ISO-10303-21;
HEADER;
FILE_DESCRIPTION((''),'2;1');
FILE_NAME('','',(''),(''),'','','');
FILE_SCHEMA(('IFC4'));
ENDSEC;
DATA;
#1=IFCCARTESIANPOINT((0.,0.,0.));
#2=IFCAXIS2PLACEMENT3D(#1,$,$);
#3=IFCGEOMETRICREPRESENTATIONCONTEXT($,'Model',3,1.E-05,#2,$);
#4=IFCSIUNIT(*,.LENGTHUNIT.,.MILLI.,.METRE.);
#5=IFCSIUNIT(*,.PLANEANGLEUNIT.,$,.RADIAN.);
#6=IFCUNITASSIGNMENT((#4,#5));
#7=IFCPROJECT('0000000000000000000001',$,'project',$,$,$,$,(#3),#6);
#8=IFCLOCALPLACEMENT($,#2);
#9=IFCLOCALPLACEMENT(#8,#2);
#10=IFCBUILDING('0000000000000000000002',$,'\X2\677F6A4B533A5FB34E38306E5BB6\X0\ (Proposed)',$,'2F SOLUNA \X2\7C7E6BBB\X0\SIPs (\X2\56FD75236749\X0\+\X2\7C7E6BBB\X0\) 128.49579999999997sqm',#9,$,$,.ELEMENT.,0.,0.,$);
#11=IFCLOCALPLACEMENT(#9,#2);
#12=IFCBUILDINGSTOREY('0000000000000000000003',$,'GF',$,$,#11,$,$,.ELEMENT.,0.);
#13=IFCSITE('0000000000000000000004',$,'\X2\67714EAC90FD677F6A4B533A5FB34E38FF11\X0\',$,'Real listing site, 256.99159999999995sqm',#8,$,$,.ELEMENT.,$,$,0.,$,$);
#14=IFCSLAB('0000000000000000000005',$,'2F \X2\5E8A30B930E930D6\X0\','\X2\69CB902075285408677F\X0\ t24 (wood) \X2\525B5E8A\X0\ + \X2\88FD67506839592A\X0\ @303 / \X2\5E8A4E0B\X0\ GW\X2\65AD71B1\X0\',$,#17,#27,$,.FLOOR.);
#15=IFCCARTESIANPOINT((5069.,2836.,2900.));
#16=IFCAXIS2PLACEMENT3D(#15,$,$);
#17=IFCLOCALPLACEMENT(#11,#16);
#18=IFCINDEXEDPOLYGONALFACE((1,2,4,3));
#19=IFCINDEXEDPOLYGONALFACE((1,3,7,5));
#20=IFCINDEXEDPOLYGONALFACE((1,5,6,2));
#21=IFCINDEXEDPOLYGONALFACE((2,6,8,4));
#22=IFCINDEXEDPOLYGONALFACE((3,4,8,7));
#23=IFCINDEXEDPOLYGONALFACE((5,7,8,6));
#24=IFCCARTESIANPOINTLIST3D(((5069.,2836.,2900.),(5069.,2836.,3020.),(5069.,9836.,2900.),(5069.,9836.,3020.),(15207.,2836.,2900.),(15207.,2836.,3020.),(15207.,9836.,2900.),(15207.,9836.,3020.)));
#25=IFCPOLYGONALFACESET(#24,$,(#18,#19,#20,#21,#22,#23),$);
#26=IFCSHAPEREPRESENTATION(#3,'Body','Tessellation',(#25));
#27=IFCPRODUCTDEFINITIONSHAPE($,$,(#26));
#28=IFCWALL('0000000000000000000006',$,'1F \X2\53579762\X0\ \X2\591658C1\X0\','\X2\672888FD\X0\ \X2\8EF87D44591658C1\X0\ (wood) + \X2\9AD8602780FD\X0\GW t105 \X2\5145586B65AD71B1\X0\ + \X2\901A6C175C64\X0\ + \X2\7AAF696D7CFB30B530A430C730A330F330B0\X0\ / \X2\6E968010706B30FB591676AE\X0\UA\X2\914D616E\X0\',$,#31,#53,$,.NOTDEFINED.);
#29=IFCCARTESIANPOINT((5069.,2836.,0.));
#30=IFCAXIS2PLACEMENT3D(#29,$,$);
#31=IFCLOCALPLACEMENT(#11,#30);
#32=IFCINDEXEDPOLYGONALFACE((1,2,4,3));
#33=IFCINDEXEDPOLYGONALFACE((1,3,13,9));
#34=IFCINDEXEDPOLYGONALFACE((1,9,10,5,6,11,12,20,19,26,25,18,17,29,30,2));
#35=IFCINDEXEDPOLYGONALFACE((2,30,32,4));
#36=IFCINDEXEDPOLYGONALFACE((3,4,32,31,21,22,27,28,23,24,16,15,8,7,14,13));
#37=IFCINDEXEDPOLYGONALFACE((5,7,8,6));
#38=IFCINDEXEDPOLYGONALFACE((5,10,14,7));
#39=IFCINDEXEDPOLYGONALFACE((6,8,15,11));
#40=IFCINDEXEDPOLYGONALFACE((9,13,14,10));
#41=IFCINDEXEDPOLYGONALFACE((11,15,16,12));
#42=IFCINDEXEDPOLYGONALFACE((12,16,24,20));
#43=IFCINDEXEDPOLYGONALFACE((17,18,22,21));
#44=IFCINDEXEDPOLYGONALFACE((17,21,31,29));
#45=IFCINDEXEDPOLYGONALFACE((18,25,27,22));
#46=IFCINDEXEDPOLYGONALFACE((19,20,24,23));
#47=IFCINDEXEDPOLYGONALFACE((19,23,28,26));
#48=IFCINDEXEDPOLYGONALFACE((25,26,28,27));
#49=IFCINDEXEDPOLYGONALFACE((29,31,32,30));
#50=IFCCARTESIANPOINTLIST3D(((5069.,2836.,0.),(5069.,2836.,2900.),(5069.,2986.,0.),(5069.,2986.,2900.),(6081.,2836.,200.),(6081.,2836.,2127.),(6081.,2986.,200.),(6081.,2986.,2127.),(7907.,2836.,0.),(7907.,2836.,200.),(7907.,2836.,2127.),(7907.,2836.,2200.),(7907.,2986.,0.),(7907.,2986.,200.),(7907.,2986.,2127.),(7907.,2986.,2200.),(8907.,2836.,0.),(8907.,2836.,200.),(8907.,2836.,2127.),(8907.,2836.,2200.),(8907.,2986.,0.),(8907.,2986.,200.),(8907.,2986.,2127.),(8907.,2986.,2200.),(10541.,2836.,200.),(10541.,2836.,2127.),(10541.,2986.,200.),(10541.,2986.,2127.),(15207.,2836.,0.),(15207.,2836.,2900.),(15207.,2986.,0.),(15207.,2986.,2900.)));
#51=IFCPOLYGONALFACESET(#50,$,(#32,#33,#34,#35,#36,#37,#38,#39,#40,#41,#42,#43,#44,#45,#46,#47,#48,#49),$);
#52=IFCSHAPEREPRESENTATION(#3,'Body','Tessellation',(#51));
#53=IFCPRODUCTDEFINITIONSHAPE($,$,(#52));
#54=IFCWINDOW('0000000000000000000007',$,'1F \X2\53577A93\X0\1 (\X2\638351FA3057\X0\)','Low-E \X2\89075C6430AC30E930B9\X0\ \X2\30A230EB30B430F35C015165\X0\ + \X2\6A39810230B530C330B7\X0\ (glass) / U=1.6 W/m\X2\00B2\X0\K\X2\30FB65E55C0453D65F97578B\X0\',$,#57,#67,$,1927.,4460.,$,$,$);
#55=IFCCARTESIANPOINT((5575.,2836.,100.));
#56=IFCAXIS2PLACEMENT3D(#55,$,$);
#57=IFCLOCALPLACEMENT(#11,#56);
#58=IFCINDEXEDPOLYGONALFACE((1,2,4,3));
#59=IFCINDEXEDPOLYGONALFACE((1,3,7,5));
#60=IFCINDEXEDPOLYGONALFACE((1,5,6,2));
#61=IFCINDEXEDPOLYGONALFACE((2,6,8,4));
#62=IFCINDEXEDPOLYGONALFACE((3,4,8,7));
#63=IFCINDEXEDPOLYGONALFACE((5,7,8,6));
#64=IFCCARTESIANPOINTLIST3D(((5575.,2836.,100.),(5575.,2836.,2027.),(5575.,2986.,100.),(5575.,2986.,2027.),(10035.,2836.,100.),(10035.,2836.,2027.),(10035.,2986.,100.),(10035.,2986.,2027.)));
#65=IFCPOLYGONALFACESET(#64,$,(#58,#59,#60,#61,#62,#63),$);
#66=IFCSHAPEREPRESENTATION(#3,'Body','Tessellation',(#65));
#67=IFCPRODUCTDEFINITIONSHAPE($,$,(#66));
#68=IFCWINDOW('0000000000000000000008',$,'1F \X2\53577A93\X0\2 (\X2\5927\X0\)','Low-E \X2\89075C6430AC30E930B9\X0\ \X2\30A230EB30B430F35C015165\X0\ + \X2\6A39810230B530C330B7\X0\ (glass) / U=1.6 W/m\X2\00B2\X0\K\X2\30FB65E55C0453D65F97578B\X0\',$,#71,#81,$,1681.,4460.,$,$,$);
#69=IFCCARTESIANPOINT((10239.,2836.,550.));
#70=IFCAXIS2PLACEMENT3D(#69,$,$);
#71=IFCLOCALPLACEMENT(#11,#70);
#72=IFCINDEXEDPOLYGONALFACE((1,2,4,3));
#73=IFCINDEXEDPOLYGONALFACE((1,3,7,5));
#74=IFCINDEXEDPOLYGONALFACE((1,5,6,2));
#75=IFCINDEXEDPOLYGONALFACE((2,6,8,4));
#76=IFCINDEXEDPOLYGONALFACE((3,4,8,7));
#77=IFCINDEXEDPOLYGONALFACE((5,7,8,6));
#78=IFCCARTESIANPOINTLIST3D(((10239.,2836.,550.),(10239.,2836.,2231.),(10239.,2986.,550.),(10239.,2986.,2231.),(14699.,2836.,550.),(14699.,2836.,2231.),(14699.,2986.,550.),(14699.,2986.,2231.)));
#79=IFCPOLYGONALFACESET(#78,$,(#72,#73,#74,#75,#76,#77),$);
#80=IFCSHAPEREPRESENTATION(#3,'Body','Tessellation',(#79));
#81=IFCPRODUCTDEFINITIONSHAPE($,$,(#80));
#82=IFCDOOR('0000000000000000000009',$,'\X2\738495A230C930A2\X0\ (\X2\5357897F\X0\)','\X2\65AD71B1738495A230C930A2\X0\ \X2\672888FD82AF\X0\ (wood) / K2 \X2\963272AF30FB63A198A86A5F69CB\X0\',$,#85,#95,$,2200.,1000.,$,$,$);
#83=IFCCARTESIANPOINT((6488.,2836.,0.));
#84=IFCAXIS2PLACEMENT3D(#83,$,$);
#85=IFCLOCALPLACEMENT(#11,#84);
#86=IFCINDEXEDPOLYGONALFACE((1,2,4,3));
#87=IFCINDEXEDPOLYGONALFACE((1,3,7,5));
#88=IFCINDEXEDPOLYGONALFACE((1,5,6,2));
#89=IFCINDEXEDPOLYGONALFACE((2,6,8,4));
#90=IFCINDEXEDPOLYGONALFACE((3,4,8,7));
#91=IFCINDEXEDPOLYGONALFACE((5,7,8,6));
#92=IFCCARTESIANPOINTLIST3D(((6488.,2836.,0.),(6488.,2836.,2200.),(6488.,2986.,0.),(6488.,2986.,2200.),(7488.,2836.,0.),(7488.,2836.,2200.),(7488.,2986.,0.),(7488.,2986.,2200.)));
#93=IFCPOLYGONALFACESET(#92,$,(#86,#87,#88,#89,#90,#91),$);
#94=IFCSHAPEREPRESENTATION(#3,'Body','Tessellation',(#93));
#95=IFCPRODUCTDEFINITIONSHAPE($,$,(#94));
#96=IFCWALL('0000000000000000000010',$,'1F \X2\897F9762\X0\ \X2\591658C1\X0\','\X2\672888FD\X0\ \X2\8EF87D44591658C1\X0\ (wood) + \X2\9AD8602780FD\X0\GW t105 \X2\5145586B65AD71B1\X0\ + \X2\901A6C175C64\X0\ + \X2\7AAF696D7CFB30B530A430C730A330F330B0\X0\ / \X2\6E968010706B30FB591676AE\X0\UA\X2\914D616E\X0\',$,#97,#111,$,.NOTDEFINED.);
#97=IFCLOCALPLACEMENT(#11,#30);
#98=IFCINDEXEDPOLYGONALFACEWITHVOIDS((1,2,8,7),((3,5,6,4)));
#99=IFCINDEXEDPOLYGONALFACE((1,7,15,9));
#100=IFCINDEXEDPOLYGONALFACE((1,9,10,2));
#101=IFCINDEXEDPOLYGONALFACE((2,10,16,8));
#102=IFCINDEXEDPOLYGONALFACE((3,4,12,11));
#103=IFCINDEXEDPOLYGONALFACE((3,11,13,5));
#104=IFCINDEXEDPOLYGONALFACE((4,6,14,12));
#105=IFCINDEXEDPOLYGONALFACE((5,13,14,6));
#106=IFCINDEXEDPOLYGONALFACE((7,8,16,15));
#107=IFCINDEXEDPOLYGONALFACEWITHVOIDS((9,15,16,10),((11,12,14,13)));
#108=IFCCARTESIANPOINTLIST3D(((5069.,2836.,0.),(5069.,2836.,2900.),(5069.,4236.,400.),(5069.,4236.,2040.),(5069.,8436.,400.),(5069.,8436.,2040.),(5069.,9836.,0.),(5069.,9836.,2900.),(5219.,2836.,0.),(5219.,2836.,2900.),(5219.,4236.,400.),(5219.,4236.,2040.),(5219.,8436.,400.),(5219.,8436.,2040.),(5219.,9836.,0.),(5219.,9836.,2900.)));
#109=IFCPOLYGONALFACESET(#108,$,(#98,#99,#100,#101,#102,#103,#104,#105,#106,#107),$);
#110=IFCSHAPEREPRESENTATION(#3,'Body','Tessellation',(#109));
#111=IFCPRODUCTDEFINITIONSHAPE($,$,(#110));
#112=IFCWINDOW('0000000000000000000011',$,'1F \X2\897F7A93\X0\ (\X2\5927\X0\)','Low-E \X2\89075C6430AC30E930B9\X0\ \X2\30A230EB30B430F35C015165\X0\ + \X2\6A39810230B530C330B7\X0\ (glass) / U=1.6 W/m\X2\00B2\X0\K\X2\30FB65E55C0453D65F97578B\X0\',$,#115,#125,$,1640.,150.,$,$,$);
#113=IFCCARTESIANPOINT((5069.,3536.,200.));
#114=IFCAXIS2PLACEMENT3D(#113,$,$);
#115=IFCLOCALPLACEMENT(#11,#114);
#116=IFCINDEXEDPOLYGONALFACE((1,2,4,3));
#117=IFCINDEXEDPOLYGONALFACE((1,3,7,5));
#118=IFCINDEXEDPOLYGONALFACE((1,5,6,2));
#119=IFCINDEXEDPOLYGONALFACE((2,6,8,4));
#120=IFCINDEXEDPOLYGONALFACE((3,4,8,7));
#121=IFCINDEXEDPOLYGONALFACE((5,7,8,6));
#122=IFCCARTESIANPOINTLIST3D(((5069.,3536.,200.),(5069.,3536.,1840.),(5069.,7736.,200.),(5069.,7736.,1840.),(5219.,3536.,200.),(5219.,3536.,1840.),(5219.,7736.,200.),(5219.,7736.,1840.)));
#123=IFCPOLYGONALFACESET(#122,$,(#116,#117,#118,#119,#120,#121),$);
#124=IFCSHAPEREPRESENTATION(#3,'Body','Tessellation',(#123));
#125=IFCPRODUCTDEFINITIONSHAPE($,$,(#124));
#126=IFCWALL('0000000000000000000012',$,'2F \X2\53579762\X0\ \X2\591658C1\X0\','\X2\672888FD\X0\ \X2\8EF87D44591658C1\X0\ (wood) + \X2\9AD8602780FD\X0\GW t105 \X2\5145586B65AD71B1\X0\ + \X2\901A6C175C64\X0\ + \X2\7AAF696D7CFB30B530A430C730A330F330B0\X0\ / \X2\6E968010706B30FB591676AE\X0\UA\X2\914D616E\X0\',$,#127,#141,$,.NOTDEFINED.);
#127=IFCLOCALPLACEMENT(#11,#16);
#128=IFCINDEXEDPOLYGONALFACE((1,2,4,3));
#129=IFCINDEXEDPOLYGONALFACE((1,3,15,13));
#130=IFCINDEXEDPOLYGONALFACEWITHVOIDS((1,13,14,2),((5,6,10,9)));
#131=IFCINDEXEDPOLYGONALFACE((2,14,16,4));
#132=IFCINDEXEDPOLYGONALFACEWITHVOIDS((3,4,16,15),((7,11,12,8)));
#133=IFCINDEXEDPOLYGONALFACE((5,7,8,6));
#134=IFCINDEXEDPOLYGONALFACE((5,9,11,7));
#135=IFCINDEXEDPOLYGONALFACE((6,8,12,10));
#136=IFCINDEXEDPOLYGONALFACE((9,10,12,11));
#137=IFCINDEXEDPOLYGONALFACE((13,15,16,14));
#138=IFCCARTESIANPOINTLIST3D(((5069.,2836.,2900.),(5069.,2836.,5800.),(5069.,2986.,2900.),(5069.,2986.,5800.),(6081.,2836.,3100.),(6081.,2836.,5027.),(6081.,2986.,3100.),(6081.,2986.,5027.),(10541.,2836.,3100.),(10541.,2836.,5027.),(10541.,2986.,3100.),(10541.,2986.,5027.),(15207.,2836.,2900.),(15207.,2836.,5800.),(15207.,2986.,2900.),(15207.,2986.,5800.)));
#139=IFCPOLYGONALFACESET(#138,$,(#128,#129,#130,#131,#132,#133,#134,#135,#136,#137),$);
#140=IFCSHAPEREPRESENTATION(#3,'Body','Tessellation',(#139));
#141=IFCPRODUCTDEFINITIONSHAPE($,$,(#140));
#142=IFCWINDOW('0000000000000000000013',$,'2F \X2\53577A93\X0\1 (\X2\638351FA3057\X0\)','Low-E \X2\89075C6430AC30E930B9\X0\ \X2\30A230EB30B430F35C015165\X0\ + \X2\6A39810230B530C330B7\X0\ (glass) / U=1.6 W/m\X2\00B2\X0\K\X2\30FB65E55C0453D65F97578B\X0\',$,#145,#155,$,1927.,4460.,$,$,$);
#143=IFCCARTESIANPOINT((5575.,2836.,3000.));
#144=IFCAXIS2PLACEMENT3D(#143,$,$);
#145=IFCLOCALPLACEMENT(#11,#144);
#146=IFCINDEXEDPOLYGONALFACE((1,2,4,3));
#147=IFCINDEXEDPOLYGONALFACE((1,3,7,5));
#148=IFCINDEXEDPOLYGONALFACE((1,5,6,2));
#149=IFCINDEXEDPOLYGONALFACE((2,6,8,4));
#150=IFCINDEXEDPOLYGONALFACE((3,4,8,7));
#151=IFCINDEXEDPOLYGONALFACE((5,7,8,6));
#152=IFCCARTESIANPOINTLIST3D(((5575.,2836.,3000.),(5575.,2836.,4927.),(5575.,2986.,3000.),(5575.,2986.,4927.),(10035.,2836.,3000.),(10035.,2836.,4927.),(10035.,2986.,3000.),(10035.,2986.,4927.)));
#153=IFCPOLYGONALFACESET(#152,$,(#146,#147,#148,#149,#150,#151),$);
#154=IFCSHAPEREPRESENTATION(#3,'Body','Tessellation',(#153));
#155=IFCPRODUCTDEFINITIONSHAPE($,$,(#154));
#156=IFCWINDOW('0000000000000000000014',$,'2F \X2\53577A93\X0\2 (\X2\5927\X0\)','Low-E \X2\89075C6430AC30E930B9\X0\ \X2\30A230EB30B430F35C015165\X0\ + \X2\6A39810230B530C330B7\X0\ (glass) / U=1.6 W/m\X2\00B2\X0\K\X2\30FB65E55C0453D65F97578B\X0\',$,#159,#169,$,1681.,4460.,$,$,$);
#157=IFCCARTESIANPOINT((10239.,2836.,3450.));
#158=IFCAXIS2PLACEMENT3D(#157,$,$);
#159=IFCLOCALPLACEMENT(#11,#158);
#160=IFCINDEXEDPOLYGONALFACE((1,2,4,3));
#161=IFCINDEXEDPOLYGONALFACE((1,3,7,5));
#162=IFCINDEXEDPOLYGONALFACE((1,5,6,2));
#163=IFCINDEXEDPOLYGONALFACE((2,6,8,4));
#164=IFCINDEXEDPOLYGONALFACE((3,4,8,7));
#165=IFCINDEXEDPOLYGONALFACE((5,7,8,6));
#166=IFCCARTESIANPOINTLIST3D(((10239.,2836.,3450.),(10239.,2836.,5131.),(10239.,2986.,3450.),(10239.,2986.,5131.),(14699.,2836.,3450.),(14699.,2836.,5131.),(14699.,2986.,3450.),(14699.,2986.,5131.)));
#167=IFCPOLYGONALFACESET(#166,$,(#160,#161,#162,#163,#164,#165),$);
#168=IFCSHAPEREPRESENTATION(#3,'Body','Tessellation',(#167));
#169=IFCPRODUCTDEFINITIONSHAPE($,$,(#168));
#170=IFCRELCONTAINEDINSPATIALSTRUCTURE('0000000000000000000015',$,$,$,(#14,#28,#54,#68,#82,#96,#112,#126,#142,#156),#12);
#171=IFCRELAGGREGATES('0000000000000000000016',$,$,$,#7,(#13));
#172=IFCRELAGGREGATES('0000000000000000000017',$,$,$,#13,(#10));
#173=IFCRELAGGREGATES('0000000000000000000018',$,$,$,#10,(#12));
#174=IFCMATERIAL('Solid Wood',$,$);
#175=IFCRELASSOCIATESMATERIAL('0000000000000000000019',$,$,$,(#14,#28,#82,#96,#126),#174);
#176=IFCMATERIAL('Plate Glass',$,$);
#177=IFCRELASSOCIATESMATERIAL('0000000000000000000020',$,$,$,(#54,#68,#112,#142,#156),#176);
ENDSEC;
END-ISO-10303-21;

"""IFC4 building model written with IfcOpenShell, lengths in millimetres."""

from ifc_helpers import new_model, si_unit, frame, frame_2d, origin, place, context, project, spatial, rectangle, extrude, material, element, fill, save


model = new_model("IFC4")

# Units and contexts
model_context = context("Model", 3, precision=1e-05, world=origin())
ifc_project = project(units=[si_unit("LENGTHUNIT", "METRE", prefix="MILLI"), si_unit("PLANEANGLEUNIT", "RADIAN")], contexts=[model_context])

# Site, building, storey
site_placement = place(None, origin())
site = spatial("IfcSite", under=ifc_project, at=site_placement, Name="東京都板橋区徳丸１", ObjectType="Real listing site, 256.99159999999995sqm", CompositionType="ELEMENT", RefElevation=0.0)
building_placement = place(site_placement, origin())
building = spatial("IfcBuilding", under=site, at=building_placement, Name="板橋区徳丸の家 (Proposed)", ObjectType="2F SOLUNA 籾殻SIPs (国産杉+籾殻) 128.49579999999997sqm", CompositionType="ELEMENT", ElevationOfRefHeight=0.0, ElevationOfTerrain=0.0)
storey_placement = place(building_placement, origin())
storey = spatial("IfcBuildingStorey", under=building, at=storey_placement, Name="GF", CompositionType="ELEMENT", Elevation=0.0)

# Slab
ifc_material_1 = material(Name="Solid Wood")
slab_1_placement = place(storey_placement, frame((5069.0, 2836.0, 2900.0)))
element("IfcSlab", 1, at=slab_1_placement, inside=storey, material=ifc_material_1, Name="2F 床スラブ", Description="構造用合板 t24 (wood) 剛床 + 製材根太 @303 / 床下 GW断熱", PredefinedType="FLOOR", context=model_context, shape_type="SweptSolid", body=[
    extrude(rectangle(XDim=10138.0, YDim=7000.0, at=frame_2d((5069.0, 3500.0))), frame((5069.0, 2836.0, 2900.0)), (0.0, 0.0, 1.0), 120.0),
])

# Wall, openings, windows, door
wall_1_placement = place(storey_placement, frame((5069.0, 2836.0, 0.0)))
wall_1 = element("IfcWall", 2, at=wall_1_placement, inside=storey, material=ifc_material_1, Name="1F 南面 外壁", Description="木製 軸組外壁 (wood) + 高性能GW t105 充填断熱 + 通気層 + 窯業系サイディング / 準耐火・外皮UA配慮", PredefinedType="NOTDEFINED", context=model_context, shape_type="SweptSolid", body=[
    extrude(rectangle(XDim=10138.0, YDim=150.0, at=frame_2d((5069.0, 75.0))), frame((5069.0, 2836.0, 0.0)), (0.0, 0.0, 1.0), 2900.0),
])
opening_1_placement = place(storey_placement, frame((5575.0, 2836.0, 100.0)))
opening_1 = element("IfcOpeningElement", 3, at=opening_1_placement, cuts=wall_1, PredefinedType="NOTDEFINED", context=model_context, shape_type="SweptSolid", body=[
    extrude(rectangle(XDim=4460.0, YDim=150.0, at=frame_2d((2230.0, 75.0))), frame((5575.0, 2836.0, 100.0)), (0.0, 0.0, 1.0), 1927.0),
])
opening_2_placement = place(storey_placement, frame((10239.0, 2836.0, 550.0)))
opening_2 = element("IfcOpeningElement", 4, at=opening_2_placement, cuts=wall_1, PredefinedType="NOTDEFINED", context=model_context, shape_type="SweptSolid", body=[
    extrude(rectangle(XDim=4460.0, YDim=150.0, at=frame_2d((2230.0, 75.0))), frame((10239.0, 2836.0, 550.0)), (0.0, 0.0, 1.0), 1681.0),
])
opening_3_placement = place(storey_placement, frame((6488.0, 2836.0, 0.0)))
opening_3 = element("IfcOpeningElement", 5, at=opening_3_placement, cuts=wall_1, PredefinedType="NOTDEFINED", context=model_context, shape_type="SweptSolid", body=[
    extrude(rectangle(XDim=1000.0, YDim=150.0, at=frame_2d((500.0, 75.0))), frame((6488.0, 2836.0, 0.0)), (0.0, 0.0, 1.0), 2200.0),
])
ifc_material_2 = material(Name="Plate Glass")
window_1_placement = place(storey_placement, frame((5575.0, 2836.0, 100.0)))
window_1 = element("IfcWindow", 6, at=window_1_placement, inside=storey, material=ifc_material_2, Name="1F 南窓1 (掃出し)", Description="Low-E 複層ガラス アルゴン封入 + 樹脂サッシ (glass) / U=1.6 W/m²K・日射取得型", OverallHeight=1927.0, OverallWidth=4460.0, context=model_context, shape_type="SweptSolid", body=[
    extrude(rectangle(XDim=4460.0, YDim=150.0, at=frame_2d((2230.0, 75.0))), frame((5575.0, 2836.0, 100.0)), (0.0, 0.0, 1.0), 1927.0),
])
fill(opening_1, window_1)
window_2_placement = place(storey_placement, frame((10239.0, 2836.0, 550.0)))
window_2 = element("IfcWindow", 7, at=window_2_placement, inside=storey, material=ifc_material_2, Name="1F 南窓2 (大)", Description="Low-E 複層ガラス アルゴン封入 + 樹脂サッシ (glass) / U=1.6 W/m²K・日射取得型", OverallHeight=1681.0, OverallWidth=4460.0, context=model_context, shape_type="SweptSolid", body=[
    extrude(rectangle(XDim=4460.0, YDim=150.0, at=frame_2d((2230.0, 75.0))), frame((10239.0, 2836.0, 550.0)), (0.0, 0.0, 1.0), 1681.0),
])
fill(opening_2, window_2)
door_placement = place(storey_placement, frame((6488.0, 2836.0, 0.0)))
door = element("IfcDoor", 8, at=door_placement, inside=storey, material=ifc_material_1, Name="玄関ドア (南西)", Description="断熱玄関ドア 木製芯 (wood) / K2 防犯・採風機構", OverallHeight=2200.0, OverallWidth=1000.0, context=model_context, shape_type="SweptSolid", body=[
    extrude(rectangle(XDim=1000.0, YDim=150.0, at=frame_2d((500.0, 75.0))), frame((6488.0, 2836.0, 0.0)), (0.0, 0.0, 1.0), 2200.0),
])
fill(opening_3, door)

# Wall, opening, window
wall_2_placement = place(storey_placement, frame((5069.0, 2836.0, 0.0)))
wall_2 = element("IfcWall", 9, at=wall_2_placement, inside=storey, material=ifc_material_1, Name="1F 西面 外壁", Description="木製 軸組外壁 (wood) + 高性能GW t105 充填断熱 + 通気層 + 窯業系サイディング / 準耐火・外皮UA配慮", PredefinedType="NOTDEFINED", context=model_context, shape_type="SweptSolid", body=[
    extrude(rectangle(XDim=150.0, YDim=7000.0, at=frame_2d((75.0, 3500.0))), frame((5069.0, 2836.0, 0.0)), (0.0, 0.0, 1.0), 2900.0),
])
opening_4_placement = place(storey_placement, frame((5069.0, 3536.0, 200.0)))
opening_4 = element("IfcOpeningElement", 10, at=opening_4_placement, cuts=wall_2, PredefinedType="NOTDEFINED", context=model_context, shape_type="SweptSolid", body=[
    extrude(rectangle(XDim=150.0, YDim=4200.0, at=frame_2d((75.0, 2100.0))), frame((5069.0, 3536.0, 200.0)), (0.0, 0.0, 1.0), 1640.0),
])
window_3_placement = place(storey_placement, frame((5069.0, 3536.0, 200.0)))
window_3 = element("IfcWindow", 11, at=window_3_placement, inside=storey, material=ifc_material_2, Name="1F 西窓 (大)", Description="Low-E 複層ガラス アルゴン封入 + 樹脂サッシ (glass) / U=1.6 W/m²K・日射取得型", OverallHeight=1640.0, OverallWidth=150.0, context=model_context, shape_type="SweptSolid", body=[
    extrude(rectangle(XDim=150.0, YDim=4200.0, at=frame_2d((75.0, 2100.0))), frame((5069.0, 3536.0, 200.0)), (0.0, 0.0, 1.0), 1640.0),
])
fill(opening_4, window_3)

# Wall, openings, windows
wall_3_placement = place(storey_placement, frame((5069.0, 2836.0, 2900.0)))
wall_3 = element("IfcWall", 12, at=wall_3_placement, inside=storey, material=ifc_material_1, Name="2F 南面 外壁", Description="木製 軸組外壁 (wood) + 高性能GW t105 充填断熱 + 通気層 + 窯業系サイディング / 準耐火・外皮UA配慮", PredefinedType="NOTDEFINED", context=model_context, shape_type="SweptSolid", body=[
    extrude(rectangle(XDim=10138.0, YDim=150.0, at=frame_2d((5069.0, 75.0))), frame((5069.0, 2836.0, 2900.0)), (0.0, 0.0, 1.0), 2900.0),
])
opening_5_placement = place(storey_placement, frame((5575.0, 2836.0, 3000.0)))
opening_5 = element("IfcOpeningElement", 13, at=opening_5_placement, cuts=wall_3, PredefinedType="NOTDEFINED", context=model_context, shape_type="SweptSolid", body=[
    extrude(rectangle(XDim=4460.0, YDim=150.0, at=frame_2d((2230.0, 75.0))), frame((5575.0, 2836.0, 3000.0)), (0.0, 0.0, 1.0), 1927.0),
])
opening_6_placement = place(storey_placement, frame((10239.0, 2836.0, 3450.0)))
opening_6 = element("IfcOpeningElement", 14, at=opening_6_placement, cuts=wall_3, PredefinedType="NOTDEFINED", context=model_context, shape_type="SweptSolid", body=[
    extrude(rectangle(XDim=4460.0, YDim=150.0, at=frame_2d((2230.0, 75.0))), frame((10239.0, 2836.0, 3450.0)), (0.0, 0.0, 1.0), 1681.0),
])
window_4_placement = place(storey_placement, frame((5575.0, 2836.0, 3000.0)))
window_4 = element("IfcWindow", 15, at=window_4_placement, inside=storey, material=ifc_material_2, Name="2F 南窓1 (掃出し)", Description="Low-E 複層ガラス アルゴン封入 + 樹脂サッシ (glass) / U=1.6 W/m²K・日射取得型", OverallHeight=1927.0, OverallWidth=4460.0, context=model_context, shape_type="SweptSolid", body=[
    extrude(rectangle(XDim=4460.0, YDim=150.0, at=frame_2d((2230.0, 75.0))), frame((5575.0, 2836.0, 3000.0)), (0.0, 0.0, 1.0), 1927.0),
])
fill(opening_5, window_4)
window_5_placement = place(storey_placement, frame((10239.0, 2836.0, 3450.0)))
window_5 = element("IfcWindow", 16, at=window_5_placement, inside=storey, material=ifc_material_2, Name="2F 南窓2 (大)", Description="Low-E 複層ガラス アルゴン封入 + 樹脂サッシ (glass) / U=1.6 W/m²K・日射取得型", OverallHeight=1681.0, OverallWidth=4460.0, context=model_context, shape_type="SweptSolid", body=[
    extrude(rectangle(XDim=4460.0, YDim=150.0, at=frame_2d((2230.0, 75.0))), frame((10239.0, 2836.0, 3450.0)), (0.0, 0.0, 1.0), 1681.0),
])
fill(opening_6, window_5)

save(model, "model.ifc")
